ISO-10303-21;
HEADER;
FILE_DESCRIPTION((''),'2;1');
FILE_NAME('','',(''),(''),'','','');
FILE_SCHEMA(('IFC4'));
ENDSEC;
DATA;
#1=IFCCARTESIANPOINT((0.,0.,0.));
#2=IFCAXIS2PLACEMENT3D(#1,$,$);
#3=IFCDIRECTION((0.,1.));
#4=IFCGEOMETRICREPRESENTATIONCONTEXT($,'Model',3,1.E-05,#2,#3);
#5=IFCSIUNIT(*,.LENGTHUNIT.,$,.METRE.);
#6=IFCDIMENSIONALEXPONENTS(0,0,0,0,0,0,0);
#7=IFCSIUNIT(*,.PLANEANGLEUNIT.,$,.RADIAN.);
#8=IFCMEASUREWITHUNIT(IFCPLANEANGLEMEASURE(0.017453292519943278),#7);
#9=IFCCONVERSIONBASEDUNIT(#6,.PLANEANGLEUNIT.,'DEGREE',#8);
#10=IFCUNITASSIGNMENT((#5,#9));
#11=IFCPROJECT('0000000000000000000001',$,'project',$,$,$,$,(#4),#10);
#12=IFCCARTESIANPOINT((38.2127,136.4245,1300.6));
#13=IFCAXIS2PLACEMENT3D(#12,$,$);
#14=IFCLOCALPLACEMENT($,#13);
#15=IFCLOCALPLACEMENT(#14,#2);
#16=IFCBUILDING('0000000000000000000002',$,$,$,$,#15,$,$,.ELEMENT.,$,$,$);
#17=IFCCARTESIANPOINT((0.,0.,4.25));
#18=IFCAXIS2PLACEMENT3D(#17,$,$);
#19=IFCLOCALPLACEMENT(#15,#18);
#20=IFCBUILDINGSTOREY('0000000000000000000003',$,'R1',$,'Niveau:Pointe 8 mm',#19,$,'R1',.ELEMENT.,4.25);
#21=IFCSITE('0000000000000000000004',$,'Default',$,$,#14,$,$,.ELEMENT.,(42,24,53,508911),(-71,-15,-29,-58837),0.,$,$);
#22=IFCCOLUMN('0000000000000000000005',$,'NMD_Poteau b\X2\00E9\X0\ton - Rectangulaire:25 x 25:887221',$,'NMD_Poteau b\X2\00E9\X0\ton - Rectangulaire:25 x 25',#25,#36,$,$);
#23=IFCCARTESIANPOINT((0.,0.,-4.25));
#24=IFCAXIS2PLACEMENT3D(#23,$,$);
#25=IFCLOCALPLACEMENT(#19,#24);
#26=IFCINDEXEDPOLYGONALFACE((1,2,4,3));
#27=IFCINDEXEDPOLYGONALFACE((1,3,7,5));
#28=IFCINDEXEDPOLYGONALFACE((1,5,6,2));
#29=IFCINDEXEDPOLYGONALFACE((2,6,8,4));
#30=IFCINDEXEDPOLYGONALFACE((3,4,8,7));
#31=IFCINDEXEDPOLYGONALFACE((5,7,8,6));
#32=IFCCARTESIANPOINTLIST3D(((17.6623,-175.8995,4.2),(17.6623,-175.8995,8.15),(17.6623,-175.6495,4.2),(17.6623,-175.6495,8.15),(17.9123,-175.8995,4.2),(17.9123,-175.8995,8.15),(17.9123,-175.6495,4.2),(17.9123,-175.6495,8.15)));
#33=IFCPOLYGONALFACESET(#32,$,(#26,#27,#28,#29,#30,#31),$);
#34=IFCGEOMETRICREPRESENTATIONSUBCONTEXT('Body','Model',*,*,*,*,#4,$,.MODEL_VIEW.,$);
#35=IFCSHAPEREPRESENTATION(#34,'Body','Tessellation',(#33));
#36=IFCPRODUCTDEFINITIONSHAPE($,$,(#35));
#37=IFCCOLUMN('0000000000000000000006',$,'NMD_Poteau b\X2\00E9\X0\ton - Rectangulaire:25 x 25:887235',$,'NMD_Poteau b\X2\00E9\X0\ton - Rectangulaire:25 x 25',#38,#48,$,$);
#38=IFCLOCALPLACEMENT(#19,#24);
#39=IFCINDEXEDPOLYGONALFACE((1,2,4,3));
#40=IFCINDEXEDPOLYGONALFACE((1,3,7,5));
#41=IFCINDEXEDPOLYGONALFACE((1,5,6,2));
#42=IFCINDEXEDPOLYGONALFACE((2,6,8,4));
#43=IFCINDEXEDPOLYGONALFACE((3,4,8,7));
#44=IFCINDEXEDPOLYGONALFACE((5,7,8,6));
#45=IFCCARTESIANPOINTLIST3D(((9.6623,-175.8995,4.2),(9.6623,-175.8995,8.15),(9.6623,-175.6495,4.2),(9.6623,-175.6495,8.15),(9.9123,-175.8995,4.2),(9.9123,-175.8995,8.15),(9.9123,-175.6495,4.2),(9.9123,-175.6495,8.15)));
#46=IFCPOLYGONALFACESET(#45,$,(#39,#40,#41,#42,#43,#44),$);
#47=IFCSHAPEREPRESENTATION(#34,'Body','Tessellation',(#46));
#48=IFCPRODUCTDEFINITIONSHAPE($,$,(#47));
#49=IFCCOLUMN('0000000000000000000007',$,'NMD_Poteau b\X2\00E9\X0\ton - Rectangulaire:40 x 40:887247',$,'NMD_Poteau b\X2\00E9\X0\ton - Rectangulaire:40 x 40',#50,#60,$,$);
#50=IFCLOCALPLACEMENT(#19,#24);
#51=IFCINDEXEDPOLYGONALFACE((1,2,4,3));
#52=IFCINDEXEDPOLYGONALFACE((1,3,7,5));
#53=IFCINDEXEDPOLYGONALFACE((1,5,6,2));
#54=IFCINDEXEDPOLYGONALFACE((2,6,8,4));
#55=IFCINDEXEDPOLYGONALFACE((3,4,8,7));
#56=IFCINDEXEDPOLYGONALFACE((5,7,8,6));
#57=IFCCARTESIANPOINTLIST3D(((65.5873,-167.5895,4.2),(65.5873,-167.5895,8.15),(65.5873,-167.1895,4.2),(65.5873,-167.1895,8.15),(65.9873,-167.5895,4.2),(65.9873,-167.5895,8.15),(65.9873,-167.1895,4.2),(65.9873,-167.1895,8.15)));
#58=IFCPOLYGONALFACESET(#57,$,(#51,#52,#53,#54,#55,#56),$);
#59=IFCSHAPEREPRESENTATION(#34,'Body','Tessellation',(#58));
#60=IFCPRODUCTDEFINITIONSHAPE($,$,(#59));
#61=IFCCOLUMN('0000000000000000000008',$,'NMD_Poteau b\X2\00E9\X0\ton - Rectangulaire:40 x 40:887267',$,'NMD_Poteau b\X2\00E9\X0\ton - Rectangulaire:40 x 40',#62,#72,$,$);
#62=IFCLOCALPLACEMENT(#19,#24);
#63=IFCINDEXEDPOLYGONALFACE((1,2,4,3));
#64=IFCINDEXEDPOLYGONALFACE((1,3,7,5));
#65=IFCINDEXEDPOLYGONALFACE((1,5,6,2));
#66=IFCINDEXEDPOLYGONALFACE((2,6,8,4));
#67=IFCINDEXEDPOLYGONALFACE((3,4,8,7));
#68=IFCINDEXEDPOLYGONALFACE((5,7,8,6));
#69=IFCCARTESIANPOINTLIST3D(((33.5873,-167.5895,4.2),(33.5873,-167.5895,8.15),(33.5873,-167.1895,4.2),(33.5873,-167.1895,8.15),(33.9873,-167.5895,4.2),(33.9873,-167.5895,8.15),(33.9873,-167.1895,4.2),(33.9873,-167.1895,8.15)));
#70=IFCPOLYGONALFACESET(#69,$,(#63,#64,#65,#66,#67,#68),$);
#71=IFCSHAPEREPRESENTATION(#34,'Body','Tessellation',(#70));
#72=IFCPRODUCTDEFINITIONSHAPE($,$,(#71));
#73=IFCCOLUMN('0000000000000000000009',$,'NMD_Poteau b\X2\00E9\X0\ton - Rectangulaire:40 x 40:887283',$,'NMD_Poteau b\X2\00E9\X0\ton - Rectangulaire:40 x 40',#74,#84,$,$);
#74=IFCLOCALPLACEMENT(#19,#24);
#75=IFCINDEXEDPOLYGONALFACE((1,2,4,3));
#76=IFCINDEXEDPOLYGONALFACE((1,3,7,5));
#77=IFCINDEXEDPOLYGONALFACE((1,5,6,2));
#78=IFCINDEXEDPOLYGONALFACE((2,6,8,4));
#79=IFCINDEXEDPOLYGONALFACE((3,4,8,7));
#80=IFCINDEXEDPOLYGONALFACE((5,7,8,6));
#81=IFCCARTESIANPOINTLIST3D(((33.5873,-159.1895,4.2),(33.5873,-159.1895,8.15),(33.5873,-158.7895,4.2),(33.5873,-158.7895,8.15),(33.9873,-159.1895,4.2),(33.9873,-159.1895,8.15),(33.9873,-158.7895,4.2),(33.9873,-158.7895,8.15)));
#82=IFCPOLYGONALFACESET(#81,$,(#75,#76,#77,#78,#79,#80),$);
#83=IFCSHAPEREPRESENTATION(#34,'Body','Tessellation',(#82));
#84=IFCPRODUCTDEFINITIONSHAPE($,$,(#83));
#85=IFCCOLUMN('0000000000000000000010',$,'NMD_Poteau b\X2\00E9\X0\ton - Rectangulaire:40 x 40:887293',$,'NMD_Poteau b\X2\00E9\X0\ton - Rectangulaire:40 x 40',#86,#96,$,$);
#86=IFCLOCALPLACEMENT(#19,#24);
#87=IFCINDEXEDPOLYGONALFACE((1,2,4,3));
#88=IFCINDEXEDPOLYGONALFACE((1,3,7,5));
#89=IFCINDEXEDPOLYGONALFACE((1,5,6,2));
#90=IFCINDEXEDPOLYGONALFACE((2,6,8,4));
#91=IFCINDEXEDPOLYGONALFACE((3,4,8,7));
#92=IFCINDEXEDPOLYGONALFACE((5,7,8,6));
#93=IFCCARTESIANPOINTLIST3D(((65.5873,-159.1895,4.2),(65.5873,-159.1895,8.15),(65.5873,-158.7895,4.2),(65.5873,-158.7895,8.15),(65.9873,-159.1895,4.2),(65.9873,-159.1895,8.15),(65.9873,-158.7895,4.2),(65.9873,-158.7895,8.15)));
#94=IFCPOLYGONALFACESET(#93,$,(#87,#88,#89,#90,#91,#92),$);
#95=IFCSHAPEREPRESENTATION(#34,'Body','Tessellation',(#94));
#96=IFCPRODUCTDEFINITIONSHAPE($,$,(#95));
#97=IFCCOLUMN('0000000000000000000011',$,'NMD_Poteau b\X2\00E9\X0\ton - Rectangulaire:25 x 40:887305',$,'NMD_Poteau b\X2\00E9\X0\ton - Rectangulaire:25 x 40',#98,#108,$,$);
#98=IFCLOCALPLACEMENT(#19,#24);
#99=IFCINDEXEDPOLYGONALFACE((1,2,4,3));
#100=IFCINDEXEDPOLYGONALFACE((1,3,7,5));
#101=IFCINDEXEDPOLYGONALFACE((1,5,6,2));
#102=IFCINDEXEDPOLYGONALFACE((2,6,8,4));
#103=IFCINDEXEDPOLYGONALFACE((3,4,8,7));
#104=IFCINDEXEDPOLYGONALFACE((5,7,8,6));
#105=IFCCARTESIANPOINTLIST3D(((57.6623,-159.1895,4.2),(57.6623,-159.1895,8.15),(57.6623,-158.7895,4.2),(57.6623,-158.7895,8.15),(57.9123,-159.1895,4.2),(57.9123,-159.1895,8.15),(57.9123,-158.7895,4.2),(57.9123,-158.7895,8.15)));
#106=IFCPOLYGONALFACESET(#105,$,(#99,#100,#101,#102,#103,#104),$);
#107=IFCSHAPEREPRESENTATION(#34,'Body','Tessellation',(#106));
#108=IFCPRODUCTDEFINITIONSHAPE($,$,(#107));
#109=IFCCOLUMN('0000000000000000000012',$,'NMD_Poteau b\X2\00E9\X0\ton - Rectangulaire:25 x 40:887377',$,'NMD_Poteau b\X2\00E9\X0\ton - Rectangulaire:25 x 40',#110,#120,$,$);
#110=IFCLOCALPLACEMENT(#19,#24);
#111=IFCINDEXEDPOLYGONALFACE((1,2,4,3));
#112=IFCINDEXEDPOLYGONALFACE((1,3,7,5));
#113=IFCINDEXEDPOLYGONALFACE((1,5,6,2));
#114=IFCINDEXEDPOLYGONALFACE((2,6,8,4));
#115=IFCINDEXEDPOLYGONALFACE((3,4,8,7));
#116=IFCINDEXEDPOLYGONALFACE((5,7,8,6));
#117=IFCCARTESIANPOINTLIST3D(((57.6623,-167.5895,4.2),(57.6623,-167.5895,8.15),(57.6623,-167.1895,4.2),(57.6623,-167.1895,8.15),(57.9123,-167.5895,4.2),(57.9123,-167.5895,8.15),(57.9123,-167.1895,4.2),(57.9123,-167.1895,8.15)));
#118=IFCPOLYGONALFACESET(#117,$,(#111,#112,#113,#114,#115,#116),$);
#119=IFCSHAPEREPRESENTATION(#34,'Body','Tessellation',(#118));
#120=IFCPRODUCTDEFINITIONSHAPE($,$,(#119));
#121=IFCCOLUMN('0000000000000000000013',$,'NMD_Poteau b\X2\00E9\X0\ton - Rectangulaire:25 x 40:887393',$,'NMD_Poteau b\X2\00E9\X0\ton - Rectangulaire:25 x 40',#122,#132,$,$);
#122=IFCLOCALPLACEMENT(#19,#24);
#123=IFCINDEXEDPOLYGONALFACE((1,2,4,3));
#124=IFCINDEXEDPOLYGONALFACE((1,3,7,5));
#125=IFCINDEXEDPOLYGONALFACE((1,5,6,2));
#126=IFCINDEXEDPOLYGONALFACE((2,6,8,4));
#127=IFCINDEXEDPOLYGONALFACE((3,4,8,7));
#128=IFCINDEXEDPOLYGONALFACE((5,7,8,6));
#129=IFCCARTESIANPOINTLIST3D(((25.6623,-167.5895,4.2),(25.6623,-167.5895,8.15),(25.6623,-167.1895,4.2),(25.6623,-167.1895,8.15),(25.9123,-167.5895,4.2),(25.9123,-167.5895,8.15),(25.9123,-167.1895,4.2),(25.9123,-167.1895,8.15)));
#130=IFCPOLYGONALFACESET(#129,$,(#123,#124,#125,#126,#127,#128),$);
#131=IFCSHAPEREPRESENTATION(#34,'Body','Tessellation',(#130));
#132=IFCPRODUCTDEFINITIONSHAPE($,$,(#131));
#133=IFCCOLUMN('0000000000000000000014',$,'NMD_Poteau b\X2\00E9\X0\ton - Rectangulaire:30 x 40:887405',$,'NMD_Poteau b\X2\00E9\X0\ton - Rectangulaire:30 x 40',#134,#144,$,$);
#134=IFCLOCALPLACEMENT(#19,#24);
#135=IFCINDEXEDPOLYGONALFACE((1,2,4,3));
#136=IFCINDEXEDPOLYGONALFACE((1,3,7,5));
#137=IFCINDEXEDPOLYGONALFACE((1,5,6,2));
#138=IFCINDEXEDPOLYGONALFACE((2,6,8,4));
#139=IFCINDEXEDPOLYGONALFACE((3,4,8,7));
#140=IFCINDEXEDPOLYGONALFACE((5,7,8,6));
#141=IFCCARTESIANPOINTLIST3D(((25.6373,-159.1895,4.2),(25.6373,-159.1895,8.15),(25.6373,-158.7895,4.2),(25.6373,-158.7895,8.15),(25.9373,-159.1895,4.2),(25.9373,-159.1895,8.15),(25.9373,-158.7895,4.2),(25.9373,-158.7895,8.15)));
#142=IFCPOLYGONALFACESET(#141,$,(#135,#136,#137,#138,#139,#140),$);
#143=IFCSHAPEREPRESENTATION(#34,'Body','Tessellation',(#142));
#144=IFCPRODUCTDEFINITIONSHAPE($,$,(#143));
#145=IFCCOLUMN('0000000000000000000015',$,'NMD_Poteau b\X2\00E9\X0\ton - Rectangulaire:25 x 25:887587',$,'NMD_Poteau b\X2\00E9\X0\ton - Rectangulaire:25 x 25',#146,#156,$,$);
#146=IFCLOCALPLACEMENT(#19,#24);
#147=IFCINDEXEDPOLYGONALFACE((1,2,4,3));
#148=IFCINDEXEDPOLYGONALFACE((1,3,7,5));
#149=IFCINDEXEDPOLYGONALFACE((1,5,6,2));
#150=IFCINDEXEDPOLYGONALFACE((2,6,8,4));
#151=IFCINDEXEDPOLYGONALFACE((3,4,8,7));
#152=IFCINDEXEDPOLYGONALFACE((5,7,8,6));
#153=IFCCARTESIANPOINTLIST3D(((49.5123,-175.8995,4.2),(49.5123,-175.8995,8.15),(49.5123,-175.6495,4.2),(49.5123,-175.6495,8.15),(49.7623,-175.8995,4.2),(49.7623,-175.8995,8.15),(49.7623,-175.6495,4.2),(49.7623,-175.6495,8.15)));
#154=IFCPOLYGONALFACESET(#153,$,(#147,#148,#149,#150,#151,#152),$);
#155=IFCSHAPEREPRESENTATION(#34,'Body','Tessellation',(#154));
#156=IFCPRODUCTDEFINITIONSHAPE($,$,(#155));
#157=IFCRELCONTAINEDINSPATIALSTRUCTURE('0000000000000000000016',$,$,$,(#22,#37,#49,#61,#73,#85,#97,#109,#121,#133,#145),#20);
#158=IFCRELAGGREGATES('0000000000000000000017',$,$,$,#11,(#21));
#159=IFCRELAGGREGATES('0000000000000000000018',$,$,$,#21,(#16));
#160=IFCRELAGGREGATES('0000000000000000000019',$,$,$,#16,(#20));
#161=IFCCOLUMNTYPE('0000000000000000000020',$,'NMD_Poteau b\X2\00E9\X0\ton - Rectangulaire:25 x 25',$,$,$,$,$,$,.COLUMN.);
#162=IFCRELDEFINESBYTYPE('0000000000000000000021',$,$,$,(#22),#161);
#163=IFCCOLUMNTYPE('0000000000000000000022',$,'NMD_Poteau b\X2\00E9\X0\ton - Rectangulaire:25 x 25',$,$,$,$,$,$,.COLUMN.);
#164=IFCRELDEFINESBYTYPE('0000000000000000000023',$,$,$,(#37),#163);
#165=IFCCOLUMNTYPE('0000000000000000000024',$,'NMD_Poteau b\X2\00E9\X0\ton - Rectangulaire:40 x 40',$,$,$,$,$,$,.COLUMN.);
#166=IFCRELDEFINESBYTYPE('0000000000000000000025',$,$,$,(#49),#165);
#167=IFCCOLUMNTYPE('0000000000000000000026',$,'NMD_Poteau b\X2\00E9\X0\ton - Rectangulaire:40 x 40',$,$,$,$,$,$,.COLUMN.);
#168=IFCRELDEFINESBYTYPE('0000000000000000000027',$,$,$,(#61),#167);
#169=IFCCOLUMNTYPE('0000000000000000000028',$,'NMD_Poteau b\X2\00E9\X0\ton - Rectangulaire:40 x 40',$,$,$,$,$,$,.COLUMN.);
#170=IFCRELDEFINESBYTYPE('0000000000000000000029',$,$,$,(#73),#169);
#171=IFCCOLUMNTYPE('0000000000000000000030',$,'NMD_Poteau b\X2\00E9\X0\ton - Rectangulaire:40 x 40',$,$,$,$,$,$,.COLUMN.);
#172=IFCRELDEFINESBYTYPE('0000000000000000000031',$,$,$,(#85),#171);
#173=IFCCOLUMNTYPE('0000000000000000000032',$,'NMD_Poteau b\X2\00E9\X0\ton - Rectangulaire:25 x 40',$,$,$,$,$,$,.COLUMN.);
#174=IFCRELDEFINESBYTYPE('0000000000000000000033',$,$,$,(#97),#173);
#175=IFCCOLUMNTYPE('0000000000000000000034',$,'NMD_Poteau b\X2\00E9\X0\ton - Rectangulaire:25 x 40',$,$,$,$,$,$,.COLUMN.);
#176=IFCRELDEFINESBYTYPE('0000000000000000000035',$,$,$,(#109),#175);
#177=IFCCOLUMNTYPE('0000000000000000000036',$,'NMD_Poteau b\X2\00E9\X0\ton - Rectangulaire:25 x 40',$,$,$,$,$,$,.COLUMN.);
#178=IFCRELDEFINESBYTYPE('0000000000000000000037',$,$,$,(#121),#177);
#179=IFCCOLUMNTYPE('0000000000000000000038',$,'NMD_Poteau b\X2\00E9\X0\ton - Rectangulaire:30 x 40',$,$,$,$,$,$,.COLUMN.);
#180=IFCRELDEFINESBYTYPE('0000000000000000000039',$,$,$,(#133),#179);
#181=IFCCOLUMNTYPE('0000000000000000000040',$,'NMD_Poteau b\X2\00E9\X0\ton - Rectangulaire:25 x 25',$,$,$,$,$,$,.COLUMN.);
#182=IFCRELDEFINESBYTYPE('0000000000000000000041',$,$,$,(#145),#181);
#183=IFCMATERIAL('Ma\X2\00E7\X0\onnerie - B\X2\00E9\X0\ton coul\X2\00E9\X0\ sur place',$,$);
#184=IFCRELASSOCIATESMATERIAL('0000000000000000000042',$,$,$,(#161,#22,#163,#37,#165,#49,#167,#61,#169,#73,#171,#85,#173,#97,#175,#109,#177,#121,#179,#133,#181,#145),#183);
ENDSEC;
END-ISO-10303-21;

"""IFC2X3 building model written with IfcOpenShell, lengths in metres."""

from ifc_helpers import new_model, entity, si_unit, converted_unit, direction, frame, frame_2d, origin, place, context, subcontext, project, spatial, rectangle, extrude, source, transform, mapped, material, type_object, type_shapes, element, save


model = new_model("IFC2X3")

# Units and contexts
model_context = context("Model", 3, precision=1e-05, world=origin(), true_north=direction((0.0, 1.0)))
body_context = subcontext(model_context, "Body", "Model", "MODEL_VIEW")
ifc_project = project(units=[si_unit("LENGTHUNIT", "METRE"), converted_unit("PLANEANGLEUNIT", "DEGREE", entity("IfcPlaneAngleMeasure", 0.017453292519943278), si_unit("PLANEANGLEUNIT", "RADIAN"), dimensions=[0, 0, 0, 0, 0, 0, 0])], contexts=[model_context])

# Site, building, storey
site_placement = place(None, frame((38.2127, 136.4245, 1300.6)))
site = spatial("IfcSite", under=ifc_project, at=site_placement, Name="Default", CompositionType="ELEMENT", RefLatitude=(42, 24, 53, 508911), RefLongitude=(-71, -15, -29, -58837), RefElevation=0.0)
building_placement = place(site_placement, origin())
building = spatial("IfcBuilding", under=site, at=building_placement, CompositionType="ELEMENT")
storey_placement = place(building_placement, frame((0.0, 0.0, 4.25)))
storey = spatial("IfcBuildingStorey", under=building, at=storey_placement, Name="R1", ObjectType="Niveau:Pointe 8 mm", LongName="R1", CompositionType="ELEMENT", Elevation=4.25)

# Columns
ifc_material = material(Name="Maçonnerie - Béton coulé sur place")
column_type_1 = type_object("IfcColumnType", Name="NMD_Poteau béton - Rectangulaire:25 x 25", PredefinedType="COLUMN", material=ifc_material)
shared_shape_1 = source(origin(), body_context, "Body", "SweptSolid", [
    extrude(rectangle(XDim=0.25, YDim=0.25, at=frame_2d((0.0, 0.0), x_axis=(1.0, 0.0))), frame((17.7873, -175.7745, 4.2), z_axis=(0.0, 0.0, 1.0), x_axis=(-1.0, 0.0, 0.0)), (0.0, 0.0, 1.0), 3.95),
])
type_shapes(column_type_1, [shared_shape_1])
column_1_placement = place(storey_placement, frame((0.0, 0.0, -4.25)))
element("IfcColumn", 1, at=column_1_placement, inside=storey, type_object=column_type_1, material=ifc_material, Name="NMD_Poteau béton - Rectangulaire:25 x 25:887221", ObjectType="NMD_Poteau béton - Rectangulaire:25 x 25", context=body_context, shape_type="MappedRepresentation", body=[
    mapped(shared_shape_1, transform((0.0, 0.0, 0.0), scale=1.0)),
])
column_type_2 = type_object("IfcColumnType", Name="NMD_Poteau béton - Rectangulaire:25 x 25", PredefinedType="COLUMN", material=ifc_material)
shared_shape_2 = source(origin(), body_context, "Body", "SweptSolid", [
    extrude(rectangle(XDim=0.25, YDim=0.25, at=frame_2d((0.0, 0.0), x_axis=(1.0, 0.0))), frame((9.7873, -175.7745, 4.2), z_axis=(0.0, 0.0, 1.0), x_axis=(-1.0, 0.0, 0.0)), (0.0, 0.0, 1.0), 3.95),
])
type_shapes(column_type_2, [shared_shape_2])
column_2_placement = place(storey_placement, frame((0.0, 0.0, -4.25)))
element("IfcColumn", 2, at=column_2_placement, inside=storey, type_object=column_type_2, material=ifc_material, Name="NMD_Poteau béton - Rectangulaire:25 x 25:887235", ObjectType="NMD_Poteau béton - Rectangulaire:25 x 25", context=body_context, shape_type="MappedRepresentation", body=[
    mapped(shared_shape_2, transform((0.0, 0.0, 0.0), scale=1.0)),
])
column_type_3 = type_object("IfcColumnType", Name="NMD_Poteau béton - Rectangulaire:40 x 40", PredefinedType="COLUMN", material=ifc_material)
shared_shape_3 = source(origin(), body_context, "Body", "SweptSolid", [
    extrude(rectangle(XDim=0.4, YDim=0.4, at=frame_2d((0.0, 0.0), x_axis=(1.0, 0.0))), frame((65.7873, -167.3895, 4.2), z_axis=(0.0, 0.0, 1.0), x_axis=(-1.0, 0.0, 0.0)), (0.0, 0.0, 1.0), 3.95),
])
type_shapes(column_type_3, [shared_shape_3])
column_3_placement = place(storey_placement, frame((0.0, 0.0, -4.25)))
element("IfcColumn", 3, at=column_3_placement, inside=storey, type_object=column_type_3, material=ifc_material, Name="NMD_Poteau béton - Rectangulaire:40 x 40:887247", ObjectType="NMD_Poteau béton - Rectangulaire:40 x 40", context=body_context, shape_type="MappedRepresentation", body=[
    mapped(shared_shape_3, transform((0.0, 0.0, 0.0), scale=1.0)),
])
column_type_4 = type_object("IfcColumnType", Name="NMD_Poteau béton - Rectangulaire:40 x 40", PredefinedType="COLUMN", material=ifc_material)
shared_shape_4 = source(origin(), body_context, "Body", "SweptSolid", [
    extrude(rectangle(XDim=0.4, YDim=0.4, at=frame_2d((0.0, 0.0), x_axis=(1.0, 0.0))), frame((33.7873, -167.3895, 4.2), z_axis=(0.0, 0.0, 1.0), x_axis=(-1.0, 0.0, 0.0)), (0.0, 0.0, 1.0), 3.95),
])
type_shapes(column_type_4, [shared_shape_4])
column_4_placement = place(storey_placement, frame((0.0, 0.0, -4.25)))
element("IfcColumn", 4, at=column_4_placement, inside=storey, type_object=column_type_4, material=ifc_material, Name="NMD_Poteau béton - Rectangulaire:40 x 40:887267", ObjectType="NMD_Poteau béton - Rectangulaire:40 x 40", context=body_context, shape_type="MappedRepresentation", body=[
    mapped(shared_shape_4, transform((0.0, 0.0, 0.0), scale=1.0)),
])
column_type_5 = type_object("IfcColumnType", Name="NMD_Poteau béton - Rectangulaire:40 x 40", PredefinedType="COLUMN", material=ifc_material)
shared_shape_5 = source(origin(), body_context, "Body", "SweptSolid", [
    extrude(rectangle(XDim=0.4, YDim=0.4, at=frame_2d((0.0, 0.0), x_axis=(1.0, 0.0))), frame((33.7873, -158.9895, 4.2), z_axis=(0.0, 0.0, 1.0), x_axis=(-1.0, 0.0, 0.0)), (0.0, 0.0, 1.0), 3.95),
])
type_shapes(column_type_5, [shared_shape_5])
column_5_placement = place(storey_placement, frame((0.0, 0.0, -4.25)))
element("IfcColumn", 5, at=column_5_placement, inside=storey, type_object=column_type_5, material=ifc_material, Name="NMD_Poteau béton - Rectangulaire:40 x 40:887283", ObjectType="NMD_Poteau béton - Rectangulaire:40 x 40", context=body_context, shape_type="MappedRepresentation", body=[
    mapped(shared_shape_5, transform((0.0, 0.0, 0.0), scale=1.0)),
])
column_type_6 = type_object("IfcColumnType", Name="NMD_Poteau béton - Rectangulaire:40 x 40", PredefinedType="COLUMN", material=ifc_material)
shared_shape_6 = source(origin(), body_context, "Body", "SweptSolid", [
    extrude(rectangle(XDim=0.4, YDim=0.4, at=frame_2d((0.0, 0.0), x_axis=(1.0, 0.0))), frame((65.7873, -158.9895, 4.2), z_axis=(0.0, 0.0, 1.0), x_axis=(-1.0, 0.0, 0.0)), (0.0, 0.0, 1.0), 3.95),
])
type_shapes(column_type_6, [shared_shape_6])
column_6_placement = place(storey_placement, frame((0.0, 0.0, -4.25)))
element("IfcColumn", 6, at=column_6_placement, inside=storey, type_object=column_type_6, material=ifc_material, Name="NMD_Poteau béton - Rectangulaire:40 x 40:887293", ObjectType="NMD_Poteau béton - Rectangulaire:40 x 40", context=body_context, shape_type="MappedRepresentation", body=[
    mapped(shared_shape_6, transform((0.0, 0.0, 0.0), scale=1.0)),
])
column_type_7 = type_object("IfcColumnType", Name="NMD_Poteau béton - Rectangulaire:25 x 40", PredefinedType="COLUMN", material=ifc_material)
shared_shape_7 = source(origin(), body_context, "Body", "SweptSolid", [
    extrude(rectangle(XDim=0.25, YDim=0.4, at=frame_2d((0.0, 0.0), x_axis=(1.0, 0.0))), frame((57.7873, -158.9895, 4.2)), (0.0, 0.0, 1.0), 3.95),
])
type_shapes(column_type_7, [shared_shape_7])
column_7_placement = place(storey_placement, frame((0.0, 0.0, -4.25)))
element("IfcColumn", 7, at=column_7_placement, inside=storey, type_object=column_type_7, material=ifc_material, Name="NMD_Poteau béton - Rectangulaire:25 x 40:887305", ObjectType="NMD_Poteau béton - Rectangulaire:25 x 40", context=body_context, shape_type="MappedRepresentation", body=[
    mapped(shared_shape_7, transform((0.0, 0.0, 0.0), scale=1.0)),
])
column_type_8 = type_object("IfcColumnType", Name="NMD_Poteau béton - Rectangulaire:25 x 40", PredefinedType="COLUMN", material=ifc_material)
shared_shape_8 = source(origin(), body_context, "Body", "SweptSolid", [
    extrude(rectangle(XDim=0.25, YDim=0.4, at=frame_2d((0.0, 0.0), x_axis=(1.0, 0.0))), frame((57.7873, -167.3895, 4.2), z_axis=(0.0, 0.0, 1.0), x_axis=(-1.0, 0.0, 0.0)), (0.0, 0.0, 1.0), 3.95),
])
type_shapes(column_type_8, [shared_shape_8])
column_8_placement = place(storey_placement, frame((0.0, 0.0, -4.25)))
element("IfcColumn", 8, at=column_8_placement, inside=storey, type_object=column_type_8, material=ifc_material, Name="NMD_Poteau béton - Rectangulaire:25 x 40:887377", ObjectType="NMD_Poteau béton - Rectangulaire:25 x 40", context=body_context, shape_type="MappedRepresentation", body=[
    mapped(shared_shape_8, transform((0.0, 0.0, 0.0), scale=1.0)),
])
column_type_9 = type_object("IfcColumnType", Name="NMD_Poteau béton - Rectangulaire:25 x 40", PredefinedType="COLUMN", material=ifc_material)
shared_shape_9 = source(origin(), body_context, "Body", "SweptSolid", [
    extrude(rectangle(XDim=0.25, YDim=0.4, at=frame_2d((0.0, 0.0), x_axis=(1.0, 0.0))), frame((25.7873, -167.3895, 4.2), z_axis=(0.0, 0.0, 1.0), x_axis=(-1.0, 0.0, 0.0)), (0.0, 0.0, 1.0), 3.95),
])
type_shapes(column_type_9, [shared_shape_9])
column_9_placement = place(storey_placement, frame((0.0, 0.0, -4.25)))
element("IfcColumn", 9, at=column_9_placement, inside=storey, type_object=column_type_9, material=ifc_material, Name="NMD_Poteau béton - Rectangulaire:25 x 40:887393", ObjectType="NMD_Poteau béton - Rectangulaire:25 x 40", context=body_context, shape_type="MappedRepresentation", body=[
    mapped(shared_shape_9, transform((0.0, 0.0, 0.0), scale=1.0)),
])
column_type_10 = type_object("IfcColumnType", Name="NMD_Poteau béton - Rectangulaire:30 x 40", PredefinedType="COLUMN", material=ifc_material)
shared_shape_10 = source(origin(), body_context, "Body", "SweptSolid", [
    extrude(rectangle(XDim=0.3, YDim=0.4, at=frame_2d((0.0, 0.0), x_axis=(1.0, 0.0))), frame((25.7873, -158.9895, 4.2)), (0.0, 0.0, 1.0), 3.95),
])
type_shapes(column_type_10, [shared_shape_10])
column_10_placement = place(storey_placement, frame((0.0, 0.0, -4.25)))
element("IfcColumn", 10, at=column_10_placement, inside=storey, type_object=column_type_10, material=ifc_material, Name="NMD_Poteau béton - Rectangulaire:30 x 40:887405", ObjectType="NMD_Poteau béton - Rectangulaire:30 x 40", context=body_context, shape_type="MappedRepresentation", body=[
    mapped(shared_shape_10, transform((0.0, 0.0, 0.0), scale=1.0)),
])
column_type_11 = type_object("IfcColumnType", Name="NMD_Poteau béton - Rectangulaire:25 x 25", PredefinedType="COLUMN", material=ifc_material)
shared_shape_11 = source(origin(), body_context, "Body", "SweptSolid", [
    extrude(rectangle(XDim=0.25, YDim=0.25, at=frame_2d((0.0, 0.0), x_axis=(1.0, 0.0))), frame((49.6373, -175.7745, 4.2), z_axis=(0.0, 0.0, 1.0), x_axis=(-1.0, 0.0, 0.0)), (0.0, 0.0, 1.0), 3.95),
])
type_shapes(column_type_11, [shared_shape_11])
column_11_placement = place(storey_placement, frame((0.0, 0.0, -4.25)))
element("IfcColumn", 11, at=column_11_placement, inside=storey, type_object=column_type_11, material=ifc_material, Name="NMD_Poteau béton - Rectangulaire:25 x 25:887587", ObjectType="NMD_Poteau béton - Rectangulaire:25 x 25", context=body_context, shape_type="MappedRepresentation", body=[
    mapped(shared_shape_11, transform((0.0, 0.0, 0.0), scale=1.0)),
])

save(model, "model.ifc")
